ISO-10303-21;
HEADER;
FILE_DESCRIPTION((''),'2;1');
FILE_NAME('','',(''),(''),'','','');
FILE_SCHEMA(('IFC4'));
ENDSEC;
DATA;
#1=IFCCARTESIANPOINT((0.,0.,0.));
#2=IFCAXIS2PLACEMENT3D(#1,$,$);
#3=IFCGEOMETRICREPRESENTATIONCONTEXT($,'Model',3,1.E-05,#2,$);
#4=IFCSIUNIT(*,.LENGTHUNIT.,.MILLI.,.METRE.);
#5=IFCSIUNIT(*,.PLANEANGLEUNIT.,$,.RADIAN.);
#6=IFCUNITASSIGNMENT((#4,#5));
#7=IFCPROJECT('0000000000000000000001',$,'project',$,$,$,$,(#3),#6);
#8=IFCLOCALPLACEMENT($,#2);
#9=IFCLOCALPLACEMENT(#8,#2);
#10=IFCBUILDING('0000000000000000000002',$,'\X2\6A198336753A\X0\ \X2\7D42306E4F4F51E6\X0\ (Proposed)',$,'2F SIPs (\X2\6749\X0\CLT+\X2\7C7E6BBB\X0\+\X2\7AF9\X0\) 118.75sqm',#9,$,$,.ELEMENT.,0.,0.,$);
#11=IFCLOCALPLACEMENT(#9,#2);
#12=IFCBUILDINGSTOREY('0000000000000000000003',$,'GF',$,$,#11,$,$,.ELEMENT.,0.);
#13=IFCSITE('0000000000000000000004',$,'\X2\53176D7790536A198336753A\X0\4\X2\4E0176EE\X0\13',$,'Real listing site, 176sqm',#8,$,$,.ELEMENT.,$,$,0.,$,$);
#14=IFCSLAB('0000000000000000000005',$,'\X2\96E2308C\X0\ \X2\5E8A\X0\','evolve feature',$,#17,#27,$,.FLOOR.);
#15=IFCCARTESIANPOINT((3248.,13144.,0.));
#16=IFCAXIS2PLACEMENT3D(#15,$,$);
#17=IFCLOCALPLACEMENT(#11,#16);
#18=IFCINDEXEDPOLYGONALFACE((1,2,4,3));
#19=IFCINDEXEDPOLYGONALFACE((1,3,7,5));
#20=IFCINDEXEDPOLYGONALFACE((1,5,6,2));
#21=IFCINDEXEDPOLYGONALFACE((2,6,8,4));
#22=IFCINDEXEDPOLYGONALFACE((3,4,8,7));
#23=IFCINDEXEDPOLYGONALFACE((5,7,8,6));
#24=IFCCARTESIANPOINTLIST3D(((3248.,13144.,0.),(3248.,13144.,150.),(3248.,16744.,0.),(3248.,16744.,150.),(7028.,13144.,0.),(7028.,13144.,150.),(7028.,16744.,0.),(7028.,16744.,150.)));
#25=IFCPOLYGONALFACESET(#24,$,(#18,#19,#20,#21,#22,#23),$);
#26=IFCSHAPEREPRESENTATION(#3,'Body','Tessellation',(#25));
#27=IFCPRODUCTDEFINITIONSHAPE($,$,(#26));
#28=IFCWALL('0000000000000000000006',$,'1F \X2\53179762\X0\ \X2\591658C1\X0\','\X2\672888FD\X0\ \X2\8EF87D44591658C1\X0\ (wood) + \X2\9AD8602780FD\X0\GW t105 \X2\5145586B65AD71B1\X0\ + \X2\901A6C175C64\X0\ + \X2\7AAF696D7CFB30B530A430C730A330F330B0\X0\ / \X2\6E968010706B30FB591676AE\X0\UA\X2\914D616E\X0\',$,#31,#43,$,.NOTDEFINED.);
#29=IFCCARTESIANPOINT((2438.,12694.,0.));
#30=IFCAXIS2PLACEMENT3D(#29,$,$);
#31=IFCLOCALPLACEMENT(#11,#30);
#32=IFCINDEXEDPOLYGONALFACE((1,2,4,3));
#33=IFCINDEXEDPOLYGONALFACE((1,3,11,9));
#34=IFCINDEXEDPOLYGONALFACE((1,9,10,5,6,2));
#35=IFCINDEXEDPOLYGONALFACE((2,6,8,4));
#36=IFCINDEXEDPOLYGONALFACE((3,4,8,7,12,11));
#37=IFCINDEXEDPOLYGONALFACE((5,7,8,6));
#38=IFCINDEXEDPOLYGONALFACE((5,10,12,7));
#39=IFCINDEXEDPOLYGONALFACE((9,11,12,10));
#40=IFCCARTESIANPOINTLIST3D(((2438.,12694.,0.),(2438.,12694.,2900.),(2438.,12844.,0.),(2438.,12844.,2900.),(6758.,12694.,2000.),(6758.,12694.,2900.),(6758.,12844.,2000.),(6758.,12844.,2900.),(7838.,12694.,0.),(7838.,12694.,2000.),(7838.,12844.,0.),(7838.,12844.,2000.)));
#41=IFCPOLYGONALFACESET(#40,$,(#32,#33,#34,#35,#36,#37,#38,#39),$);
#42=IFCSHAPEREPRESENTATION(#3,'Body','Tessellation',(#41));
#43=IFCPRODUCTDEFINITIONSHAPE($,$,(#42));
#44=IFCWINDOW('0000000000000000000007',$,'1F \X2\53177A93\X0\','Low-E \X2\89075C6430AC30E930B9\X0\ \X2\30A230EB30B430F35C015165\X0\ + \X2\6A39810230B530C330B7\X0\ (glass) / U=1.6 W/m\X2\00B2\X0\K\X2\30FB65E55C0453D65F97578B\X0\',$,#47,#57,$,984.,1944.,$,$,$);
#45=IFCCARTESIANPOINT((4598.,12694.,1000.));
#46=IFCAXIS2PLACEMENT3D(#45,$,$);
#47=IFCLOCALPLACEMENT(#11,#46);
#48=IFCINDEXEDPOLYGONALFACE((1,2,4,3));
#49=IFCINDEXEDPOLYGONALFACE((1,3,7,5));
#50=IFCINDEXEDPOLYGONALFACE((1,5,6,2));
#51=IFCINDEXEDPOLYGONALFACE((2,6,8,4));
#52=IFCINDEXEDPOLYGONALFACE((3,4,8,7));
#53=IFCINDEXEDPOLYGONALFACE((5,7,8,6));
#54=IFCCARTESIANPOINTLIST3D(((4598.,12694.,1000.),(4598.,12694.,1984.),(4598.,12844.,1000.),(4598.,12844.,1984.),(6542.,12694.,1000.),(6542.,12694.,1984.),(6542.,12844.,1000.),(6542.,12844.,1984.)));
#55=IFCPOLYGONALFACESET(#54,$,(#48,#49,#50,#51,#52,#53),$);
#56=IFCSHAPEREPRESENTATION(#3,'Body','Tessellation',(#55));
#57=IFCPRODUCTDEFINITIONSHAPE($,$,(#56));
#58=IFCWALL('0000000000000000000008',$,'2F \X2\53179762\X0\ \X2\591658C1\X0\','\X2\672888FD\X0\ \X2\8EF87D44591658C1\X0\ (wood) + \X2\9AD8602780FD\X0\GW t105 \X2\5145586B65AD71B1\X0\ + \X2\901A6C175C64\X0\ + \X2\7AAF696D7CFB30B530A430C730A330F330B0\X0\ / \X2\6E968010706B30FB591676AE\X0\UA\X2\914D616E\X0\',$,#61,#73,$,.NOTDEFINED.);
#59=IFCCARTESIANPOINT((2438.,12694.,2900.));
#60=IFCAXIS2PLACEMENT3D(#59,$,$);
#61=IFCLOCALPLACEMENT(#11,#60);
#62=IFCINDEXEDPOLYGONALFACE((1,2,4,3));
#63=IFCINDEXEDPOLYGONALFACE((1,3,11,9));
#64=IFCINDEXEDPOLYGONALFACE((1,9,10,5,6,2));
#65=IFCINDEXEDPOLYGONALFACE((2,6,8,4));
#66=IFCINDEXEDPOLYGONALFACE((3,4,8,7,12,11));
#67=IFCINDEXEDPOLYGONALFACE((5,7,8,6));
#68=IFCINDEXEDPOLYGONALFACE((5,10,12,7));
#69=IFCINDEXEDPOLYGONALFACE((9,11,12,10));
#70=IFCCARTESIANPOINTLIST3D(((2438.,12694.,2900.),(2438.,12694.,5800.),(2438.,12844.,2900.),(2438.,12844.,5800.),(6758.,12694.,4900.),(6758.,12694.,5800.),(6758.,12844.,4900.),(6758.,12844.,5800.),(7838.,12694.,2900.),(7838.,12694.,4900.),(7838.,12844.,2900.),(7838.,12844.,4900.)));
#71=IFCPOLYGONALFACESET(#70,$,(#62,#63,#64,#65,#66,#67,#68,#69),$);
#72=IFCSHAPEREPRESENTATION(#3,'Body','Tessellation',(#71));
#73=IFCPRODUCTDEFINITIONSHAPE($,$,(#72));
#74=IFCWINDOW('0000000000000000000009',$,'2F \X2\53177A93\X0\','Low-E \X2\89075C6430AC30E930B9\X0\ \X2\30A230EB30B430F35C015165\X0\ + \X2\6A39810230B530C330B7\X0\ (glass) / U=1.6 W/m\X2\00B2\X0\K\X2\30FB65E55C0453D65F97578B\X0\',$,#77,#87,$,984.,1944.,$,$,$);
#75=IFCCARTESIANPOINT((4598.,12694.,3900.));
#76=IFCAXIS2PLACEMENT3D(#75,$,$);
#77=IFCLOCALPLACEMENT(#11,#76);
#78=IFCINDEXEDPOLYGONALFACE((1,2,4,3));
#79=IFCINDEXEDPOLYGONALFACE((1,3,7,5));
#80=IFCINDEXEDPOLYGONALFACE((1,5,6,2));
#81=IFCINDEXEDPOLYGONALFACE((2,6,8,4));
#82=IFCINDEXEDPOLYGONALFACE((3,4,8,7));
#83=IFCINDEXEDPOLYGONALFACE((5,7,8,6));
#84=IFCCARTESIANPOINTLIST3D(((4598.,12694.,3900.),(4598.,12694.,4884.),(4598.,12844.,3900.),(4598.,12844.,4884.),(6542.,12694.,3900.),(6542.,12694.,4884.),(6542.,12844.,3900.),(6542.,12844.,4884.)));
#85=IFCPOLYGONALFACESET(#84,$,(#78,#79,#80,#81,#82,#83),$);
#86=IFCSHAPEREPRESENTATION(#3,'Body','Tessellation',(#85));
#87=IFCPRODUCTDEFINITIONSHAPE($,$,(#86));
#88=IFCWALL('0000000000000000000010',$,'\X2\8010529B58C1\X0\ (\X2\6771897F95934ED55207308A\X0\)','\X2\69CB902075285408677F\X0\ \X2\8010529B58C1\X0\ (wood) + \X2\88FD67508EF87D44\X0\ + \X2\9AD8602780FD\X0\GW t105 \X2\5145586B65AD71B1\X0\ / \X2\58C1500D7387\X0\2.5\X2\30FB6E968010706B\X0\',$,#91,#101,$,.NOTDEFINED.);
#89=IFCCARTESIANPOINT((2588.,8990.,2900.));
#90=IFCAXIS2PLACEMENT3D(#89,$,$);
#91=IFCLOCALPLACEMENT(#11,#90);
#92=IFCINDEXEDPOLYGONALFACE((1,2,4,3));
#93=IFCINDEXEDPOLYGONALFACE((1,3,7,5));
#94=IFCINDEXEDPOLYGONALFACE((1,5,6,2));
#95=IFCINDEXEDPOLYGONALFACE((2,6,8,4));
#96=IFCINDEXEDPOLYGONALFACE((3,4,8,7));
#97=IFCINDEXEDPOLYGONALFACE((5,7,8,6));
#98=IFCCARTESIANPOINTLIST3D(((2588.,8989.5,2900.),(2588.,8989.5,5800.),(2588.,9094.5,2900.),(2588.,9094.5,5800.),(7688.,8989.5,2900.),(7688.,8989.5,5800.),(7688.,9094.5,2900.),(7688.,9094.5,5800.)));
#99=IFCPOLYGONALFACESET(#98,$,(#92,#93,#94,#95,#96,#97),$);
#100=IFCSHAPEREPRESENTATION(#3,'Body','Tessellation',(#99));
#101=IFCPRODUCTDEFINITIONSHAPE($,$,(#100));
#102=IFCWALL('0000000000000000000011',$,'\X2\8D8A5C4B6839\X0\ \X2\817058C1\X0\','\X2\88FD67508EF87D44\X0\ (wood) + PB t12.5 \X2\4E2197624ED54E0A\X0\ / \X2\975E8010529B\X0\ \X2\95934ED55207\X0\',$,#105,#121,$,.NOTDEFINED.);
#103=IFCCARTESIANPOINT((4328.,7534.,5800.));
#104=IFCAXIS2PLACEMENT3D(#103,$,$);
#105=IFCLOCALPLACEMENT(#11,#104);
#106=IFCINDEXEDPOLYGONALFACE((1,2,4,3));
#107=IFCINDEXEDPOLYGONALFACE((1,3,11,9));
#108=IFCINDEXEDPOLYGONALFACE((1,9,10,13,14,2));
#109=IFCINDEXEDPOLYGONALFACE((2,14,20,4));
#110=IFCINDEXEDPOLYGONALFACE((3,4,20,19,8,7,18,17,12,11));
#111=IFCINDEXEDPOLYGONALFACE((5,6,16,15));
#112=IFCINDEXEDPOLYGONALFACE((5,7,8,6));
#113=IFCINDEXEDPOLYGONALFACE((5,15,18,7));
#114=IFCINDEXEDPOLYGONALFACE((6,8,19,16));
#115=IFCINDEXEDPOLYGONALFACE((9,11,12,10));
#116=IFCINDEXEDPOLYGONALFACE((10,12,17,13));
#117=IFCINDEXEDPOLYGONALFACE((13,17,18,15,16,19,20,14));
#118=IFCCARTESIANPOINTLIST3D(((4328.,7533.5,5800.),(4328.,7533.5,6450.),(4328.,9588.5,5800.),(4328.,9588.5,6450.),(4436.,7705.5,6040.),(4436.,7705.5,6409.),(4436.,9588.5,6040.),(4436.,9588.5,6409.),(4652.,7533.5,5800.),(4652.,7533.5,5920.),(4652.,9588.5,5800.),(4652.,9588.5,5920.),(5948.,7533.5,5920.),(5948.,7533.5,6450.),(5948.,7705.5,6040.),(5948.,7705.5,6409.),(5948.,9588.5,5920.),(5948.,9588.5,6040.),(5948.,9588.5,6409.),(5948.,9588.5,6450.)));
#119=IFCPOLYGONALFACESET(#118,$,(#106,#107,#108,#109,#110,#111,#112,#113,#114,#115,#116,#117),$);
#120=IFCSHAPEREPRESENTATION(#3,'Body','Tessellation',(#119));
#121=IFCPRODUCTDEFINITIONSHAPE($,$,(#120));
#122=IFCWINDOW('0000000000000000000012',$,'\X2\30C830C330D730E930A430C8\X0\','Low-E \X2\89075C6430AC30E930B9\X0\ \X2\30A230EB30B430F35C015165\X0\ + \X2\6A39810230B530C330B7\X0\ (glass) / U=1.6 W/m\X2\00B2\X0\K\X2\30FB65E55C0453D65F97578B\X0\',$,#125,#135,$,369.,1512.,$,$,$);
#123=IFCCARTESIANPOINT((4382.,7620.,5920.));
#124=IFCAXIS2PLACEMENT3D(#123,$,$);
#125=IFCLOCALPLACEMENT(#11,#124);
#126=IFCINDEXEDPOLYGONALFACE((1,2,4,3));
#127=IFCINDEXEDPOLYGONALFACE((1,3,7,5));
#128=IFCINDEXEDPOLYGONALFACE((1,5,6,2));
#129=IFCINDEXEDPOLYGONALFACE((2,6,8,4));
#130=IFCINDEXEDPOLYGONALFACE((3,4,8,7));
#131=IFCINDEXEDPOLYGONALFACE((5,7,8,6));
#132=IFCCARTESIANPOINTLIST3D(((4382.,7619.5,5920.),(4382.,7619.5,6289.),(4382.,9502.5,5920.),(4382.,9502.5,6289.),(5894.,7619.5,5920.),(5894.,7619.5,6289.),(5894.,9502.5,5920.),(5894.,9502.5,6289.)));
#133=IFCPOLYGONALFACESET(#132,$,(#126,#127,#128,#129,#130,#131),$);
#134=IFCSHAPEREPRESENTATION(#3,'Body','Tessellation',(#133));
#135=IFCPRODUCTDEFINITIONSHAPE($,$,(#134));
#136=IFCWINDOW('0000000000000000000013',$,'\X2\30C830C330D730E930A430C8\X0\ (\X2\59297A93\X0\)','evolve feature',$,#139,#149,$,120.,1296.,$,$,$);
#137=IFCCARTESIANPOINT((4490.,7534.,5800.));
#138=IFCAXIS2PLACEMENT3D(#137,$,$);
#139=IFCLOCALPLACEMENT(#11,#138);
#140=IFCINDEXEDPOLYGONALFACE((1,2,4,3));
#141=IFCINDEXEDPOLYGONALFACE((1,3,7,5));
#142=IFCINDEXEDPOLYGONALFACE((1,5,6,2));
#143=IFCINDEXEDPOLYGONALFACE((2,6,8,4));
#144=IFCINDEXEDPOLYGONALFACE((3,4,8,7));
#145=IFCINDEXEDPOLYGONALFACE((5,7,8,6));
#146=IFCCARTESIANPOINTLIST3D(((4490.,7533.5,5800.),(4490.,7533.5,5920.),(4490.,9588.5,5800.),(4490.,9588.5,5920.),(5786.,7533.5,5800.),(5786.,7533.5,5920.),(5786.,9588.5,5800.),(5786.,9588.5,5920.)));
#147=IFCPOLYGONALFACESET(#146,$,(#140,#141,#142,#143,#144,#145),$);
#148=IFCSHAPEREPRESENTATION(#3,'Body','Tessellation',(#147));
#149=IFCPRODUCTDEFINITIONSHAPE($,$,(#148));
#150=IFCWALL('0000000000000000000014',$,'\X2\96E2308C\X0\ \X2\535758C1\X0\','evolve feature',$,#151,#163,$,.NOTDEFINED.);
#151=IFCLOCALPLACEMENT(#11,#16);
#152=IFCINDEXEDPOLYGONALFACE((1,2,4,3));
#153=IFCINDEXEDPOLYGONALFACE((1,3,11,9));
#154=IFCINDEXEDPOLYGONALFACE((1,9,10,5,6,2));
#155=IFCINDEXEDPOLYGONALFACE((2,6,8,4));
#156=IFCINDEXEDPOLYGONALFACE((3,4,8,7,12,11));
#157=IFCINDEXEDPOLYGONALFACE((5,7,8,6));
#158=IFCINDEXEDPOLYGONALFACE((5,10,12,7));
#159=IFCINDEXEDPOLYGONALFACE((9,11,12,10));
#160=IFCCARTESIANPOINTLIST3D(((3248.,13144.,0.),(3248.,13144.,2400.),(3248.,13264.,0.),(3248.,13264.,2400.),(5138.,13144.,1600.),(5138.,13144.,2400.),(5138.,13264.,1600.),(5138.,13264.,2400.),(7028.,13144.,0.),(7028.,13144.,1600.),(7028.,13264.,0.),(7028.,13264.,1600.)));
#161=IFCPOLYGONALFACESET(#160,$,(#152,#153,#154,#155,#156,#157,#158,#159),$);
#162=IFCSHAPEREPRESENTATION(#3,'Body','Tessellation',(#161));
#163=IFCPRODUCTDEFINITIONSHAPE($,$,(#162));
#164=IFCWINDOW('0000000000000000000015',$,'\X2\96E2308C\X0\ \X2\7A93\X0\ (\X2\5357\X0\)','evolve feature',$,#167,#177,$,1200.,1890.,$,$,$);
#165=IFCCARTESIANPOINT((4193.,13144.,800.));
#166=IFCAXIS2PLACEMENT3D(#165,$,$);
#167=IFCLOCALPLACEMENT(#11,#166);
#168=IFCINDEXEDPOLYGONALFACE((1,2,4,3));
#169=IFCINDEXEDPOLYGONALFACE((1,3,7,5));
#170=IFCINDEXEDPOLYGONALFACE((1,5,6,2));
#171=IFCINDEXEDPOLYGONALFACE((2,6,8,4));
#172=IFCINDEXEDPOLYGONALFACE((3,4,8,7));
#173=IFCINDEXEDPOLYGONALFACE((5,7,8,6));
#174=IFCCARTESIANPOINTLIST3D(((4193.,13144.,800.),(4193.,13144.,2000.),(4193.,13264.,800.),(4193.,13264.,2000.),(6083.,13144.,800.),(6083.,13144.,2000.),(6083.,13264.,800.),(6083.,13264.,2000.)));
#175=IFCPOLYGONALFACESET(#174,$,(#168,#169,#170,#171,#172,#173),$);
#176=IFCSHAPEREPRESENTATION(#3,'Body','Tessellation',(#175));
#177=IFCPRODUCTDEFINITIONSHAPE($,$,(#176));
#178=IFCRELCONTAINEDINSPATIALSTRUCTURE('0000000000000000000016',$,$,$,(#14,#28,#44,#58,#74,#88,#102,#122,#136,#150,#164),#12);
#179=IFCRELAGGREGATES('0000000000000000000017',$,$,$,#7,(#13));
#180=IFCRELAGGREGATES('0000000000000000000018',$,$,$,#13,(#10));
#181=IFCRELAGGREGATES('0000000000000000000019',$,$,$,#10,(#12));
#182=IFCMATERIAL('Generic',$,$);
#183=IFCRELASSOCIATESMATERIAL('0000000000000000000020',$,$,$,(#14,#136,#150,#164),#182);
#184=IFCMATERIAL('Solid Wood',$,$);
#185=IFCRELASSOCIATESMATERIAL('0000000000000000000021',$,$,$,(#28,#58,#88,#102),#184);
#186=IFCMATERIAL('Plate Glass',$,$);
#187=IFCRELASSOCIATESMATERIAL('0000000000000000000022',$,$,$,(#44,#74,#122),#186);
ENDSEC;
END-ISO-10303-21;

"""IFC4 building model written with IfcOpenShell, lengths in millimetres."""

from ifc_helpers import new_model, si_unit, frame, frame_2d, origin, place, context, project, spatial, rectangle, extrude, material, element, fill, save


model = new_model("IFC4")

# Units and contexts
model_context = context("Model", 3, precision=1e-05, world=origin())
ifc_project = project(units=[si_unit("LENGTHUNIT", "METRE", prefix="MILLI"), si_unit("PLANEANGLEUNIT", "RADIAN")], contexts=[model_context])

# Site, building, storey
site_placement = place(None, origin())
site = spatial("IfcSite", under=ifc_project, at=site_placement, Name="北海道標茶町4丁目13", ObjectType="Real listing site, 176sqm", CompositionType="ELEMENT", RefElevation=0.0)
building_placement = place(site_placement, origin())
building = spatial("IfcBuilding", under=site, at=building_placement, Name="標茶町 終の住処 (Proposed)", ObjectType="2F SIPs (杉CLT+籾殻+竹) 118.75sqm", CompositionType="ELEMENT", ElevationOfRefHeight=0.0, ElevationOfTerrain=0.0)
storey_placement = place(building_placement, origin())
storey = spatial("IfcBuildingStorey", under=building, at=storey_placement, Name="GF", CompositionType="ELEMENT", Elevation=0.0)

# Slab
ifc_material_1 = material(Name="Generic")
slab_placement = place(storey_placement, frame((3248.0, 13144.0, 0.0)))
element("IfcSlab", 1, at=slab_placement, inside=storey, material=ifc_material_1, Name="離れ 床", Description="evolve feature", PredefinedType="FLOOR", context=model_context, shape_type="SweptSolid", body=[
    extrude(rectangle(XDim=3780.0, YDim=3600.0, at=frame_2d((1890.0, 1800.0))), frame((3248.0, 13144.0, 0.0)), (0.0, 0.0, 1.0), 150.0),
])

# Wall, opening, window
ifc_material_2 = material(Name="Solid Wood")
wall_1_placement = place(storey_placement, frame((2438.0, 12694.0, 0.0)))
wall_1 = element("IfcWall", 2, at=wall_1_placement, inside=storey, material=ifc_material_2, Name="1F 北面 外壁", Description="木製 軸組外壁 (wood) + 高性能GW t105 充填断熱 + 通気層 + 窯業系サイディング / 準耐火・外皮UA配慮", PredefinedType="NOTDEFINED", context=model_context, shape_type="SweptSolid", body=[
    extrude(rectangle(XDim=5400.0, YDim=150.0, at=frame_2d((2700.0, 75.0))), frame((2438.0, 12694.0, 0.0)), (0.0, 0.0, 1.0), 2900.0),
])
opening_1_placement = place(storey_placement, frame((4598.0, 12694.0, 1000.0)))
opening_1 = element("IfcOpeningElement", 3, at=opening_1_placement, cuts=wall_1, PredefinedType="NOTDEFINED", context=model_context, shape_type="SweptSolid", body=[
    extrude(rectangle(XDim=1944.0, YDim=150.0, at=frame_2d((972.0, 75.0))), frame((4598.0, 12694.0, 1000.0)), (0.0, 0.0, 1.0), 984.0),
])
ifc_material_3 = material(Name="Plate Glass")
window_1_placement = place(storey_placement, frame((4598.0, 12694.0, 1000.0)))
window_1 = element("IfcWindow", 4, at=window_1_placement, inside=storey, material=ifc_material_3, Name="1F 北窓", Description="Low-E 複層ガラス アルゴン封入 + 樹脂サッシ (glass) / U=1.6 W/m²K・日射取得型", OverallHeight=984.0, OverallWidth=1944.0, context=model_context, shape_type="SweptSolid", body=[
    extrude(rectangle(XDim=1944.0, YDim=150.0, at=frame_2d((972.0, 75.0))), frame((4598.0, 12694.0, 1000.0)), (0.0, 0.0, 1.0), 984.0),
])
fill(opening_1, window_1)

# Wall, opening, window
wall_2_placement = place(storey_placement, frame((2438.0, 12694.0, 2900.0)))
wall_2 = element("IfcWall", 5, at=wall_2_placement, inside=storey, material=ifc_material_2, Name="2F 北面 外壁", Description="木製 軸組外壁 (wood) + 高性能GW t105 充填断熱 + 通気層 + 窯業系サイディング / 準耐火・外皮UA配慮", PredefinedType="NOTDEFINED", context=model_context, shape_type="SweptSolid", body=[
    extrude(rectangle(XDim=5400.0, YDim=150.0, at=frame_2d((2700.0, 75.0))), frame((2438.0, 12694.0, 2900.0)), (0.0, 0.0, 1.0), 2900.0),
])
opening_2_placement = place(storey_placement, frame((4598.0, 12694.0, 3900.0)))
opening_2 = element("IfcOpeningElement", 6, at=opening_2_placement, cuts=wall_2, PredefinedType="NOTDEFINED", context=model_context, shape_type="SweptSolid", body=[
    extrude(rectangle(XDim=1944.0, YDim=150.0, at=frame_2d((972.0, 75.0))), frame((4598.0, 12694.0, 3900.0)), (0.0, 0.0, 1.0), 984.0),
])
window_2_placement = place(storey_placement, frame((4598.0, 12694.0, 3900.0)))
window_2 = element("IfcWindow", 7, at=window_2_placement, inside=storey, material=ifc_material_3, Name="2F 北窓", Description="Low-E 複層ガラス アルゴン封入 + 樹脂サッシ (glass) / U=1.6 W/m²K・日射取得型", OverallHeight=984.0, OverallWidth=1944.0, context=model_context, shape_type="SweptSolid", body=[
    extrude(rectangle(XDim=1944.0, YDim=150.0, at=frame_2d((972.0, 75.0))), frame((4598.0, 12694.0, 3900.0)), (0.0, 0.0, 1.0), 984.0),
])
fill(opening_2, window_2)

# Wall
wall_3_placement = place(storey_placement, frame((2588.0, 8990.0, 2900.0)))
element("IfcWall", 8, at=wall_3_placement, inside=storey, material=ifc_material_2, Name="耐力壁 (東西間仕切り)", Description="構造用合板 耐力壁 (wood) + 製材軸組 + 高性能GW t105 充填断熱 / 壁倍率2.5・準耐火", PredefinedType="NOTDEFINED", context=model_context, shape_type="SweptSolid", body=[
    extrude(rectangle(XDim=5100.0, YDim=105.0, at=frame_2d((2550.0, 52.0))), frame((2588.0, 8990.0, 2900.0)), (0.0, 0.0, 1.0), 2900.0),
])

# Wall, openings, windows
wall_4_placement = place(storey_placement, frame((4328.0, 7534.0, 5800.0)))
wall_4 = element("IfcWall", 9, at=wall_4_placement, inside=storey, material=ifc_material_2, Name="越屋根 腰壁", Description="製材軸組 (wood) + PB t12.5 両面仕上 / 非耐力 間仕切", PredefinedType="NOTDEFINED", context=model_context, shape_type="SweptSolid", body=[
    extrude(rectangle(XDim=1620.0, YDim=2055.0, at=frame_2d((810.0, 1027.0))), frame((4328.0, 7534.0, 5800.0)), (0.0, 0.0, 1.0), 650.0),
])
opening_3_placement = place(storey_placement, frame((4382.0, 7620.0, 5920.0)))
opening_3 = element("IfcOpeningElement", 10, at=opening_3_placement, cuts=wall_4, PredefinedType="NOTDEFINED", context=model_context, shape_type="SweptSolid", body=[
    extrude(rectangle(XDim=1512.0, YDim=1883.0, at=frame_2d((756.0, 941.0))), frame((4382.0, 7620.0, 5920.0)), (0.0, 0.0, 1.0), 369.0),
])
opening_4_placement = place(storey_placement, frame((4490.0, 7534.0, 5800.0)))
opening_4 = element("IfcOpeningElement", 11, at=opening_4_placement, cuts=wall_4, PredefinedType="NOTDEFINED", context=model_context, shape_type="SweptSolid", body=[
    extrude(rectangle(XDim=1296.0, YDim=2055.0, at=frame_2d((648.0, 1027.0))), frame((4490.0, 7534.0, 5800.0)), (0.0, 0.0, 1.0), 120.0),
])
window_3_placement = place(storey_placement, frame((4382.0, 7620.0, 5920.0)))
window_3 = element("IfcWindow", 12, at=window_3_placement, inside=storey, material=ifc_material_3, Name="トップライト", Description="Low-E 複層ガラス アルゴン封入 + 樹脂サッシ (glass) / U=1.6 W/m²K・日射取得型", OverallHeight=369.0, OverallWidth=1512.0, context=model_context, shape_type="SweptSolid", body=[
    extrude(rectangle(XDim=1512.0, YDim=1883.0, at=frame_2d((756.0, 941.0))), frame((4382.0, 7620.0, 5920.0)), (0.0, 0.0, 1.0), 369.0),
])
fill(opening_3, window_3)
window_4_placement = place(storey_placement, frame((4490.0, 7534.0, 5800.0)))
window_4 = element("IfcWindow", 13, at=window_4_placement, inside=storey, material=ifc_material_1, Name="トップライト (天窓)", Description="evolve feature", OverallHeight=120.0, OverallWidth=1296.0, context=model_context, shape_type="SweptSolid", body=[
    extrude(rectangle(XDim=1296.0, YDim=2055.0, at=frame_2d((648.0, 1027.0))), frame((4490.0, 7534.0, 5800.0)), (0.0, 0.0, 1.0), 120.0),
])
fill(opening_4, window_4)

# Wall, opening, window
wall_5_placement = place(storey_placement, frame((3248.0, 13144.0, 0.0)))
wall_5 = element("IfcWall", 14, at=wall_5_placement, inside=storey, material=ifc_material_1, Name="離れ 南壁", Description="evolve feature", PredefinedType="NOTDEFINED", context=model_context, shape_type="SweptSolid", body=[
    extrude(rectangle(XDim=3780.0, YDim=120.0, at=frame_2d((1890.0, 60.0))), frame((3248.0, 13144.0, 0.0)), (0.0, 0.0, 1.0), 2400.0),
])
opening_5_placement = place(storey_placement, frame((4193.0, 13144.0, 800.0)))
opening_5 = element("IfcOpeningElement", 15, at=opening_5_placement, cuts=wall_5, PredefinedType="NOTDEFINED", context=model_context, shape_type="SweptSolid", body=[
    extrude(rectangle(XDim=1890.0, YDim=120.0, at=frame_2d((945.0, 60.0))), frame((4193.0, 13144.0, 800.0)), (0.0, 0.0, 1.0), 1200.0),
])
window_5_placement = place(storey_placement, frame((4193.0, 13144.0, 800.0)))
window_5 = element("IfcWindow", 16, at=window_5_placement, inside=storey, material=ifc_material_1, Name="離れ 窓 (南)", Description="evolve feature", OverallHeight=1200.0, OverallWidth=1890.0, context=model_context, shape_type="SweptSolid", body=[
    extrude(rectangle(XDim=1890.0, YDim=120.0, at=frame_2d((945.0, 60.0))), frame((4193.0, 13144.0, 800.0)), (0.0, 0.0, 1.0), 1200.0),
])
fill(opening_5, window_5)

save(model, "model.ifc")
